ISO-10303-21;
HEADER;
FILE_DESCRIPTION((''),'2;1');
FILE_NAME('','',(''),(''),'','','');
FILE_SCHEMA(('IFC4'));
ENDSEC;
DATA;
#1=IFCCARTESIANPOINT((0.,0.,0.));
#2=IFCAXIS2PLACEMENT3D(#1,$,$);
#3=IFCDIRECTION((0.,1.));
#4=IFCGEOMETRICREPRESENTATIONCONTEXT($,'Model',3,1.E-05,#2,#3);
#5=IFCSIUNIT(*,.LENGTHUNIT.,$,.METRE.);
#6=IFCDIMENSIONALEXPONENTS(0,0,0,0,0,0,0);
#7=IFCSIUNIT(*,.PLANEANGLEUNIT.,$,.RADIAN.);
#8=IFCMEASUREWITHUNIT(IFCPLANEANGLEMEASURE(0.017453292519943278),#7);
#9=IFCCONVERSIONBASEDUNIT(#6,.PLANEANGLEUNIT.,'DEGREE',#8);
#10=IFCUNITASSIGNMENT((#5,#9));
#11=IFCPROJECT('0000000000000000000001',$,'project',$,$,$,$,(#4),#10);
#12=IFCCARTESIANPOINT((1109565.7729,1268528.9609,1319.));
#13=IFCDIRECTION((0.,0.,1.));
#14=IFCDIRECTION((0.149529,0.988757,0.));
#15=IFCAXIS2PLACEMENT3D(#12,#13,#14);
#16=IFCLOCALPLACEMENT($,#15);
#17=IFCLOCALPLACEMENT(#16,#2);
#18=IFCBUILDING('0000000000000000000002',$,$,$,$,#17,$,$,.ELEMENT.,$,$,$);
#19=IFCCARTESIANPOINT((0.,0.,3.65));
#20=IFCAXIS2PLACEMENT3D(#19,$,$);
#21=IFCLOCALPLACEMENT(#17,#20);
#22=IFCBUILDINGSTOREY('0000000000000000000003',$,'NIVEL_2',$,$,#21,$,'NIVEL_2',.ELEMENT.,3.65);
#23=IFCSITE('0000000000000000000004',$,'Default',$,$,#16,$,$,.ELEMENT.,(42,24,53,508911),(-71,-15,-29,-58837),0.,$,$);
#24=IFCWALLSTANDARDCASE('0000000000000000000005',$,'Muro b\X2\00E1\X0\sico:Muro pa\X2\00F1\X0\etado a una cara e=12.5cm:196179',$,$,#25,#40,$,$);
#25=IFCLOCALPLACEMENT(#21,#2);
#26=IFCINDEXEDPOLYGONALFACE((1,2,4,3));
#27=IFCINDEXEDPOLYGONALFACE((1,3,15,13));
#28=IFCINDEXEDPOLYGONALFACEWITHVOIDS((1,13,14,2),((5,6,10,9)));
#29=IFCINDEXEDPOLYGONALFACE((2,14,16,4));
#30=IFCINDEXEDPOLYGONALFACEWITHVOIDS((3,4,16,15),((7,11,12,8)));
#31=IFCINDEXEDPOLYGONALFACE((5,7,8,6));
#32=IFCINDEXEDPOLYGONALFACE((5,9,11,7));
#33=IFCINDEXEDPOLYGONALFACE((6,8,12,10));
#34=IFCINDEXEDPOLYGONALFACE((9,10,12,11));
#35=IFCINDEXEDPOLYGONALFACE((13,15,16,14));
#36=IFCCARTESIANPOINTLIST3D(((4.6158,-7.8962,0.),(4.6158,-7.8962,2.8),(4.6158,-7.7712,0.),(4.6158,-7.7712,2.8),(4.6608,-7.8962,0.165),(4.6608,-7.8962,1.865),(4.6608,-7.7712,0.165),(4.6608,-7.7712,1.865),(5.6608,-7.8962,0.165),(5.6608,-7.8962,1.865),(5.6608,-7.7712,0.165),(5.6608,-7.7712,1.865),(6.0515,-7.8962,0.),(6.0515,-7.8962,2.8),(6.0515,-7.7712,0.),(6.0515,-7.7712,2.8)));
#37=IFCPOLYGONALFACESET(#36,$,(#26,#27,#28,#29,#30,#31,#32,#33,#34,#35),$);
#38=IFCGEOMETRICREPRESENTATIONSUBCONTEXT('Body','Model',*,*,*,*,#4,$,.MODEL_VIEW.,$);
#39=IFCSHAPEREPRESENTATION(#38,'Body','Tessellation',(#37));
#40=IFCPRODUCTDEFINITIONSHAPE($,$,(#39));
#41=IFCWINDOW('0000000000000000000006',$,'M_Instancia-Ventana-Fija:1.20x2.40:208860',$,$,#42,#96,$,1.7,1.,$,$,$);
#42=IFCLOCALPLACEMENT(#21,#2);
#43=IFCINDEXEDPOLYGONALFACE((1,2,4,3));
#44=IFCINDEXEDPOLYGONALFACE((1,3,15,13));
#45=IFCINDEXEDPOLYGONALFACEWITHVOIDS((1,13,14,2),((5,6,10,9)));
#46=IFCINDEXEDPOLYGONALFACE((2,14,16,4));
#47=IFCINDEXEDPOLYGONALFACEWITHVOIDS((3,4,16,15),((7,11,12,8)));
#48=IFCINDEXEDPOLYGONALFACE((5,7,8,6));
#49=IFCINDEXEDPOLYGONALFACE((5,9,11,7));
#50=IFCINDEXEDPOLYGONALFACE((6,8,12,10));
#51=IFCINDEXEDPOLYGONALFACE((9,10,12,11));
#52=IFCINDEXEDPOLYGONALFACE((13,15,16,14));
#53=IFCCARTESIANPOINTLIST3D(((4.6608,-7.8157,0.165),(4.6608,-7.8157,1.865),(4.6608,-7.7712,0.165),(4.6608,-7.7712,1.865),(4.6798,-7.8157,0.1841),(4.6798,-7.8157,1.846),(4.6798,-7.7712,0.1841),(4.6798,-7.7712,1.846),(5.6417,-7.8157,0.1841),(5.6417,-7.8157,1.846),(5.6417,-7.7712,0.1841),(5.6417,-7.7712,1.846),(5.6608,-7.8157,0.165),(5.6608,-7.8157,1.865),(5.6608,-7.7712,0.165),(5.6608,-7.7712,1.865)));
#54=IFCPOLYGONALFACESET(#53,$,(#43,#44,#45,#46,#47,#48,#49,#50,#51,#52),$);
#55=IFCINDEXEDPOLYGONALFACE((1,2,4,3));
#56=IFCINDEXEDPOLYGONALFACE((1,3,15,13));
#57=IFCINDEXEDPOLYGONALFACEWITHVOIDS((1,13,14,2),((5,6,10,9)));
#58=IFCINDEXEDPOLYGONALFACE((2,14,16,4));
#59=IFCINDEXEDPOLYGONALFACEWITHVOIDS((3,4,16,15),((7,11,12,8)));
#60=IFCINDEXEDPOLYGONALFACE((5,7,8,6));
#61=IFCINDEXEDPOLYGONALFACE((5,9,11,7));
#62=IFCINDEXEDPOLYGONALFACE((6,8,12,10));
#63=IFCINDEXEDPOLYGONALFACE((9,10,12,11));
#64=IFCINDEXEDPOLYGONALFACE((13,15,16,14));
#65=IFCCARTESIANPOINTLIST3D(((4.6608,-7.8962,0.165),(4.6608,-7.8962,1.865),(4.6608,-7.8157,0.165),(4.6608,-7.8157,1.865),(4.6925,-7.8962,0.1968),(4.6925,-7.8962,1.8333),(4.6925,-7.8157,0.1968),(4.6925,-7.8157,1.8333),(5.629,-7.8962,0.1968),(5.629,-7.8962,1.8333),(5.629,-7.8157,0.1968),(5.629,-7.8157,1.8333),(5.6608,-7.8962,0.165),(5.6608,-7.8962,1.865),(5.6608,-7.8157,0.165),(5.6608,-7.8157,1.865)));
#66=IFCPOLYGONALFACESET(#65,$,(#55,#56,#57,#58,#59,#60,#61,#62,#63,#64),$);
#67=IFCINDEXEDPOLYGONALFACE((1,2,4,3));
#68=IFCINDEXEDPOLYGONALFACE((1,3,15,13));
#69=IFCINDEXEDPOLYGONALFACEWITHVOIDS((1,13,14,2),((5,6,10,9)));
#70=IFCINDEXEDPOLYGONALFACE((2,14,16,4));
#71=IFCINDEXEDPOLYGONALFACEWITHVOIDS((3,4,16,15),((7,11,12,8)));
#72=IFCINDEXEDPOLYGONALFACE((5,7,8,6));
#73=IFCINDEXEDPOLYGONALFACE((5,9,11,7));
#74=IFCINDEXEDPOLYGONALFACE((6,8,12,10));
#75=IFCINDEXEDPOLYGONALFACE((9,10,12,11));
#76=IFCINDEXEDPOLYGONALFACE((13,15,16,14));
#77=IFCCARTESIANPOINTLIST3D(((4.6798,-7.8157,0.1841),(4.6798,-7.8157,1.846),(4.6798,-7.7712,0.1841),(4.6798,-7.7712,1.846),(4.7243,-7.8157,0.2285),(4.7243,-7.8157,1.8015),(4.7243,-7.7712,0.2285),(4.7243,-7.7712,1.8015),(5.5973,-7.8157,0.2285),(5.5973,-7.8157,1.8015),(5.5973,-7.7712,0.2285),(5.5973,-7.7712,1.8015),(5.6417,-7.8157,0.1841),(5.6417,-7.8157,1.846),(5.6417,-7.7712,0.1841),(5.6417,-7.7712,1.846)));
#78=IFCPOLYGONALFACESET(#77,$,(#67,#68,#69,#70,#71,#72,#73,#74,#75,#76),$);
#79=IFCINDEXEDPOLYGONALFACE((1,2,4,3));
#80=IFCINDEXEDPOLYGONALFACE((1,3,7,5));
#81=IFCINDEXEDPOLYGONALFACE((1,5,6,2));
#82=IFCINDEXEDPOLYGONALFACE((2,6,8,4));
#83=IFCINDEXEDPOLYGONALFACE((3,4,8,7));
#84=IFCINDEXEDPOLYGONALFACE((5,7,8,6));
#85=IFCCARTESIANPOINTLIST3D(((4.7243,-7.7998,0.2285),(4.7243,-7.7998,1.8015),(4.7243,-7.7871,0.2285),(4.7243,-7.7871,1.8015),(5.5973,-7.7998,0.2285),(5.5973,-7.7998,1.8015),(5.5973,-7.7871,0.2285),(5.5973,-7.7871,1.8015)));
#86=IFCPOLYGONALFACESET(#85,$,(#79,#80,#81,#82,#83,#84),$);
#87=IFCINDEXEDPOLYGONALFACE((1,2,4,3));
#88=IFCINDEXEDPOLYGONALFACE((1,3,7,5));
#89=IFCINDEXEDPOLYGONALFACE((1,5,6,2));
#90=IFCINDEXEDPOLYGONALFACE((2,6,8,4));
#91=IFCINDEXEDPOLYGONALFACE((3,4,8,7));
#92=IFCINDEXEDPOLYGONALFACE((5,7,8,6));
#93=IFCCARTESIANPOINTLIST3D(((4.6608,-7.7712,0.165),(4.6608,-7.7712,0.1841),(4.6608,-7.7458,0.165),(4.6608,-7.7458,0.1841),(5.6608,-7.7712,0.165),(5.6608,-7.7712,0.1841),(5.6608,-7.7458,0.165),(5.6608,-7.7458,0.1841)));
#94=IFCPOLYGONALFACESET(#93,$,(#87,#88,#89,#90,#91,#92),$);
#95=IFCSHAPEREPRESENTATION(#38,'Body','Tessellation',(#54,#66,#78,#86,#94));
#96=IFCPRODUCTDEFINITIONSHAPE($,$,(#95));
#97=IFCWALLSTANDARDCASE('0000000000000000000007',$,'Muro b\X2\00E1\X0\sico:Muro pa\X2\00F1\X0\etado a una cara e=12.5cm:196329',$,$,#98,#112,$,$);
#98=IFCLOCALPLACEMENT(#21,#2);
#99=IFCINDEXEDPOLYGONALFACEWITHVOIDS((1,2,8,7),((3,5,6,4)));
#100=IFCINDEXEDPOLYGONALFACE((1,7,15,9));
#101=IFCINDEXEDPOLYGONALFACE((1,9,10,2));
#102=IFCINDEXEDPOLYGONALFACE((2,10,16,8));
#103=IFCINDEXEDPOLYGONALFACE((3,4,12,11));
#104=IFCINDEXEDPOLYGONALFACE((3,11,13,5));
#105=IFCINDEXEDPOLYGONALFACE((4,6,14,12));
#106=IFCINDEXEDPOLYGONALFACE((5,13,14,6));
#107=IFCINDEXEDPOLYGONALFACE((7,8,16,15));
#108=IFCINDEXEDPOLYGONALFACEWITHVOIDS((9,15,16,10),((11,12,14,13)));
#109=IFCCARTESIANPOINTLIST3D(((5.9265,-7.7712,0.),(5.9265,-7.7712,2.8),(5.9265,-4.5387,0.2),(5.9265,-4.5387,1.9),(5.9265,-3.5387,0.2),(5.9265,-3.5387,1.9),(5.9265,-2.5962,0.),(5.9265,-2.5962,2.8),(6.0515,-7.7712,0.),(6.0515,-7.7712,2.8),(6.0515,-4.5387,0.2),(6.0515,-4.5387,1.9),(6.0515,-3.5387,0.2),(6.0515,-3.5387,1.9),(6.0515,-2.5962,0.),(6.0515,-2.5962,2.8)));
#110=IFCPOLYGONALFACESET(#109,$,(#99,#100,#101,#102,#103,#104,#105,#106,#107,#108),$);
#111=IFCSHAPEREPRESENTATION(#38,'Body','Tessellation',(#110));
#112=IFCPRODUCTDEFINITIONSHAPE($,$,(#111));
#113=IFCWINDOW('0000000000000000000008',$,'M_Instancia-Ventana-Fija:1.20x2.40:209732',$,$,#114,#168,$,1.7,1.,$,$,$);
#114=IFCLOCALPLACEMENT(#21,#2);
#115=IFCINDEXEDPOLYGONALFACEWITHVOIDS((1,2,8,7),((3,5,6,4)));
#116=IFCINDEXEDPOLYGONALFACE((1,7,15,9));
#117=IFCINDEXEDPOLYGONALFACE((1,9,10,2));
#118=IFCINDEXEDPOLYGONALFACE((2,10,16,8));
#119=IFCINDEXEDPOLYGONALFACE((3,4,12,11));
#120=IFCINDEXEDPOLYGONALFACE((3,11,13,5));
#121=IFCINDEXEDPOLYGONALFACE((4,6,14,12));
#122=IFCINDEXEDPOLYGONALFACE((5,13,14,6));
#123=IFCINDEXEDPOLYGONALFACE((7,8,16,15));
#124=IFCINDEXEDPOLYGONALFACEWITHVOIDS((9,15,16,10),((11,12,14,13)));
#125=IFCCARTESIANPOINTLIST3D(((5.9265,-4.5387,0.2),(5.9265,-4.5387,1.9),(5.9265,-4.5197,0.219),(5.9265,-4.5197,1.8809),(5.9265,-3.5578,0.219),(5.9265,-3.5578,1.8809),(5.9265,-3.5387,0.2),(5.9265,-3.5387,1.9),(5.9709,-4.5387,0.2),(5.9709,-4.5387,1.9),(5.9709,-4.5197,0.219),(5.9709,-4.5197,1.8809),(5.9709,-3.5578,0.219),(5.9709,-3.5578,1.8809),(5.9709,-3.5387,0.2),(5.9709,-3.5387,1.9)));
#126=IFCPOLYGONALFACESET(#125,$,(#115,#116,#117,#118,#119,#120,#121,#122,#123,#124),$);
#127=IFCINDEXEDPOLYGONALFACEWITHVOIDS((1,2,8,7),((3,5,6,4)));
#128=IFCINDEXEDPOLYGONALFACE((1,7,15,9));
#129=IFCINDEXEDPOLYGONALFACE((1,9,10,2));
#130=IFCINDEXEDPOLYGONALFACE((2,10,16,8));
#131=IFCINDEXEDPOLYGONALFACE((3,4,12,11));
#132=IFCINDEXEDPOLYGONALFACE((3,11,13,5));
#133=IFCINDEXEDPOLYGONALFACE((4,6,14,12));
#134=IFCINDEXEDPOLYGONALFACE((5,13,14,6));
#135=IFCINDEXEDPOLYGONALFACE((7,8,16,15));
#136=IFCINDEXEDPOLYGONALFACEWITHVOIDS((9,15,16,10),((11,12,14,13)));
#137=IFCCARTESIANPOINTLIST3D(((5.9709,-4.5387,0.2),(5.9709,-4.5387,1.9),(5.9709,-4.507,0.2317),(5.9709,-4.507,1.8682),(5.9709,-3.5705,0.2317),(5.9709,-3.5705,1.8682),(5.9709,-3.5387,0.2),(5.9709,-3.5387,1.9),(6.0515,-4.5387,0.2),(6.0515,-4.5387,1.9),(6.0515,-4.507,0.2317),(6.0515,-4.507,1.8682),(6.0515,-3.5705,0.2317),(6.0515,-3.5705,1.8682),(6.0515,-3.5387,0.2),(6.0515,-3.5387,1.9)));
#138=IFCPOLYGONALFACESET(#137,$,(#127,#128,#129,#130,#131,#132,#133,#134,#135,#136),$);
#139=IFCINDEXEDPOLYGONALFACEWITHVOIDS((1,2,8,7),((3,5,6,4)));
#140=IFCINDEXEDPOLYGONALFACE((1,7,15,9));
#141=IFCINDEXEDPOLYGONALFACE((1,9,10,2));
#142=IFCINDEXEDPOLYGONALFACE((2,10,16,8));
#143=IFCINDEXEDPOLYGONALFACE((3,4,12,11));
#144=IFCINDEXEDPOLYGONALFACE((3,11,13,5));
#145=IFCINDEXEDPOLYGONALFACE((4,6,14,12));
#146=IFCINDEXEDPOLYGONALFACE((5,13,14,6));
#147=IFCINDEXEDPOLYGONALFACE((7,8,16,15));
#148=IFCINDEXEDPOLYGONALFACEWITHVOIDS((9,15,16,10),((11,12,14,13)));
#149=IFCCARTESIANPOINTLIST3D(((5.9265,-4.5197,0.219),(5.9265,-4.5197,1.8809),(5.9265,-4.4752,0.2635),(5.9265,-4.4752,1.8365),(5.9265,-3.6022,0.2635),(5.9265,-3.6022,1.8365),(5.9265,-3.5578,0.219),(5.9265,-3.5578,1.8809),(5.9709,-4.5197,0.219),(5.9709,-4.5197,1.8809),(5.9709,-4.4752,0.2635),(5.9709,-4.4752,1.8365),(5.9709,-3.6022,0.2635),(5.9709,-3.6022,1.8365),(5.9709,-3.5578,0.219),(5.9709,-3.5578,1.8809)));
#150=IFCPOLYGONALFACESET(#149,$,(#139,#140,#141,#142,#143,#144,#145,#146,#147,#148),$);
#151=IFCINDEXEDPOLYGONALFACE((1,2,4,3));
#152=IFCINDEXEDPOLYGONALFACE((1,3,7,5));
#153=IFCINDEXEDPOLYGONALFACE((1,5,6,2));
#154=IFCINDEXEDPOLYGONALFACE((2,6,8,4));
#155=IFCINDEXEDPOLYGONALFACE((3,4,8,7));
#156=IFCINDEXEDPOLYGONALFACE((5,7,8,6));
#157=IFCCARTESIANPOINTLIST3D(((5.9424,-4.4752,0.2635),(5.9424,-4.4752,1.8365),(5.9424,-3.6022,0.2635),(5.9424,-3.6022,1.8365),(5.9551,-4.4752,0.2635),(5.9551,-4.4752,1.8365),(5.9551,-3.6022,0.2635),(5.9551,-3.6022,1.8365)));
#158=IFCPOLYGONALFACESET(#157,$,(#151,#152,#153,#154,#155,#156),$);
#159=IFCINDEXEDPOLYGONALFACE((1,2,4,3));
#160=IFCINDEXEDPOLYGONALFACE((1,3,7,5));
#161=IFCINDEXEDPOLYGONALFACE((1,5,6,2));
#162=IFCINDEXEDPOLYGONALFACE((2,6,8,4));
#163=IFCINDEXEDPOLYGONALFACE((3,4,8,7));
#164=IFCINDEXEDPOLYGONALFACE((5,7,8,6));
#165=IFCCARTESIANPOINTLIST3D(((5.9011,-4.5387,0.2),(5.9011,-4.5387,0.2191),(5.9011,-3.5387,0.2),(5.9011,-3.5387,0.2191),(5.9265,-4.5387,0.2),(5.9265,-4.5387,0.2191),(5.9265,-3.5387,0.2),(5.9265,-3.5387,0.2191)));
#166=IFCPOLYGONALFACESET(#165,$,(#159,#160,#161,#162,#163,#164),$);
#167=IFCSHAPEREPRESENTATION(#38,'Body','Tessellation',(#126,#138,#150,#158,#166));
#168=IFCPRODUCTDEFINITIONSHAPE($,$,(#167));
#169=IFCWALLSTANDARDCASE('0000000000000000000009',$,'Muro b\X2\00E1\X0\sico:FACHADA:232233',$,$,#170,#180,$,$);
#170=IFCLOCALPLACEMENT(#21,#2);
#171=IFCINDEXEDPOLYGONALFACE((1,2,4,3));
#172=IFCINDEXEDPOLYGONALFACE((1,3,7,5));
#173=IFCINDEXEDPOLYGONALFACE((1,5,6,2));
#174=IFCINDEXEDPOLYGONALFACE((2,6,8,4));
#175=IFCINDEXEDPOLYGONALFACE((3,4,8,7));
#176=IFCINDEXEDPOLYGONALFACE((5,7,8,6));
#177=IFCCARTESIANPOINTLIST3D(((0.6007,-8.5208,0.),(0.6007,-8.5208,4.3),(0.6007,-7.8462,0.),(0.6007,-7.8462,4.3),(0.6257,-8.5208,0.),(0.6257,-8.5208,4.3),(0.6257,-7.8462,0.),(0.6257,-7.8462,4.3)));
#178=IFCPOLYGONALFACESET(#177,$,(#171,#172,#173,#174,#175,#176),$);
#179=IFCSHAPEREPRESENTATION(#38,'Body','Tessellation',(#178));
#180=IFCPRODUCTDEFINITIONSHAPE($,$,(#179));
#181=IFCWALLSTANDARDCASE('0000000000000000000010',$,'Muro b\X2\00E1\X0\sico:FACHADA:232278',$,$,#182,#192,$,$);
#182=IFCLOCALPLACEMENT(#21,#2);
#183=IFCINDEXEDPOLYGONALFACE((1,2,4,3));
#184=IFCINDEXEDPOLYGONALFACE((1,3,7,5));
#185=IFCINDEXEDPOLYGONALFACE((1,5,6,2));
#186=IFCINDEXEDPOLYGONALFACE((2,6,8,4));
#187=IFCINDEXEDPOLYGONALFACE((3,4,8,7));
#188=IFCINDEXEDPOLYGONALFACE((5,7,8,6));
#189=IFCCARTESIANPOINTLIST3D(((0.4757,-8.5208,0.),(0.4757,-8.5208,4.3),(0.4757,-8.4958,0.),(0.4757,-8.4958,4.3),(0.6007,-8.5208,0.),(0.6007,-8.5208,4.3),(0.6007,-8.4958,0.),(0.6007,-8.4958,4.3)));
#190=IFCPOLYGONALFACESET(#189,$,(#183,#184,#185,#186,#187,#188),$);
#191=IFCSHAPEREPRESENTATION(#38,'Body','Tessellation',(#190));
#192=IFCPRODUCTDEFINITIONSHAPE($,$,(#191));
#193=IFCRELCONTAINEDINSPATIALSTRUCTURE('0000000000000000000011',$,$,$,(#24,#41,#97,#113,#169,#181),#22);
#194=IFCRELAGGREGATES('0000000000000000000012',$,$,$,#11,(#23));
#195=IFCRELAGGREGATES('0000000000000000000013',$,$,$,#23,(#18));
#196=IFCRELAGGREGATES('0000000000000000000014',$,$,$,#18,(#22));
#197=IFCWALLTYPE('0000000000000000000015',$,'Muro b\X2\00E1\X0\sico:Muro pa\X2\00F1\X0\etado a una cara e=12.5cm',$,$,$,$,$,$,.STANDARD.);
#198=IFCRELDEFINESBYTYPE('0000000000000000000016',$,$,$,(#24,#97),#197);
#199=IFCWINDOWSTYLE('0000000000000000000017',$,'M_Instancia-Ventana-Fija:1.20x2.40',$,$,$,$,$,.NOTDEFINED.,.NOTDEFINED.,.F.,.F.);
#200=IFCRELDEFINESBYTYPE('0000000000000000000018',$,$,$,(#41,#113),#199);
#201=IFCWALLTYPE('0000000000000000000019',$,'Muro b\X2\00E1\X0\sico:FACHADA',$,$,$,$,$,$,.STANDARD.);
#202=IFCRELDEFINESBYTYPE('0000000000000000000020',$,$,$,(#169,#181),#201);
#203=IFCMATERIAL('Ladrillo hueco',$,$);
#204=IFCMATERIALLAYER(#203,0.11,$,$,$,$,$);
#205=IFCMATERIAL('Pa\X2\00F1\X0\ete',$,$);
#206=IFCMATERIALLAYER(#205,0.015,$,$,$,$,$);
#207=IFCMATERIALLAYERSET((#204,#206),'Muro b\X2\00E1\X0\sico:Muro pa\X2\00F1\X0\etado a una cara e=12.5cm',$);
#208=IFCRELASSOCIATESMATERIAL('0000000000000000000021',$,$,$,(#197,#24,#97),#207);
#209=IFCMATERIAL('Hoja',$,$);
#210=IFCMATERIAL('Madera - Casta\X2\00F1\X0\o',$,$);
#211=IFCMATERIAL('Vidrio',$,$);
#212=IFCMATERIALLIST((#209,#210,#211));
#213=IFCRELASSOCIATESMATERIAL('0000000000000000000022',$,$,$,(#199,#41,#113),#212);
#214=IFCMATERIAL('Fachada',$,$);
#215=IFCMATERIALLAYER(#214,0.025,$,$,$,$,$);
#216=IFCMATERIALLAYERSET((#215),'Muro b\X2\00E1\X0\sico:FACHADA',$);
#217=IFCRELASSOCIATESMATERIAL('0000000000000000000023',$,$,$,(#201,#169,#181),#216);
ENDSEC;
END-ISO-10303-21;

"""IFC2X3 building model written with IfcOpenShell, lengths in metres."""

from ifc_helpers import new_model, entity, si_unit, converted_unit, direction, frame, frame_2d, origin, origin_2d_with_axis, place, context, subcontext, project, spatial, polyline, rectangle, outline, extrude, source, transform, mapped, material, material_list, layer, layer_set, layer_usage, type_object, type_shapes, element, fill, save


model = new_model("IFC2X3")

# Units and contexts
model_context = context("Model", 3, precision=1e-05, world=origin(), true_north=direction((0.0, 1.0)))
body_context = subcontext(model_context, "Body", "Model", "MODEL_VIEW")
ifc_project = project(units=[si_unit("LENGTHUNIT", "METRE"), converted_unit("PLANEANGLEUNIT", "DEGREE", entity("IfcPlaneAngleMeasure", 0.017453292519943278), si_unit("PLANEANGLEUNIT", "RADIAN"), dimensions=[0, 0, 0, 0, 0, 0, 0])], contexts=[model_context])

# Site, building, storey
site_placement = place(None, frame((1109565.7729, 1268528.9609, 1319.0), z_axis=(0.0, 0.0, 1.0), x_axis=(0.149529, 0.988757, 0.0)))
site = spatial("IfcSite", under=ifc_project, at=site_placement, Name="Default", CompositionType="ELEMENT", RefLatitude=(42, 24, 53, 508911), RefLongitude=(-71, -15, -29, -58837), RefElevation=0.0)
building_placement = place(site_placement, origin())
building = spatial("IfcBuilding", under=site, at=building_placement, CompositionType="ELEMENT")
storey_placement = place(building_placement, frame((0.0, 0.0, 3.65)))
storey = spatial("IfcBuildingStorey", under=building, at=storey_placement, Name="NIVEL_2", LongName="NIVEL_2", CompositionType="ELEMENT", Elevation=3.65)

# Shared definitions
ifc_material_1 = material(Name="Pañete")
ifc_material_2 = material(Name="Ladrillo hueco")
ifc_layer_1 = layer(ifc_material_2, 0.11)
ifc_layer_2 = layer(ifc_material_1, 0.015)
ifc_layer_set_1 = layer_set([ifc_layer_1, ifc_layer_2], Name="Muro básico:Muro pañetado a una cara e=12.5cm")
wall_type_1 = type_object("IfcWallType", Name="Muro básico:Muro pañetado a una cara e=12.5cm", PredefinedType="STANDARD", material=ifc_layer_set_1)

# Shared definitions
ifc_material_3 = material(Name="Hoja")
ifc_material_4 = material(Name="Madera - Castaño")
ifc_material_5 = material(Name="Vidrio")
ifc_material_list = material_list([ifc_material_3, ifc_material_4, ifc_material_5])
window_style = type_object("IfcWindowStyle", Name="M_Instancia-Ventana-Fija:1.20x2.40", ConstructionType="NOTDEFINED", OperationType="NOTDEFINED", ParameterTakesPrecedence=False, Sizeable=False, material=ifc_material_list)
shared_shape = source(origin(), body_context, "Body", "SweptSolid", [
    extrude(outline(polyline([(-0.85, -0.5), (0.85, -0.5), (0.85, 0.5), (-0.85, 0.5), (-0.85, -0.5)]), holes=[polyline([(-0.8309, -0.4809), (-0.8309, 0.481), (0.831, 0.481), (0.831, -0.4809), (-0.8309, -0.4809)])]), frame((0.5, 0.0806, 0.85), z_axis=(0.0, 1.0, 0.0), x_axis=(0.0, 0.0, -1.0)), (0.0, 0.0, 1.0), 0.0444),
    extrude(outline(polyline([(-0.5, -0.85), (0.5, -0.85), (0.5, 0.85), (-0.5, 0.85), (-0.5, -0.85)]), holes=[polyline([(-0.4683, -0.8182), (-0.4683, 0.8183), (0.4682, 0.8183), (0.4682, -0.8182), (-0.4683, -0.8182)])]), frame((0.5, 0.0, 0.85), z_axis=(0.0, 1.0, 0.0), x_axis=(1.0, 0.0, 0.0)), (0.0, 0.0, 1.0), 0.0806),
    extrude(outline(polyline([(-0.4809, -0.831), (0.4809, -0.831), (0.4809, 0.831), (-0.4809, 0.831), (-0.4809, -0.831)]), holes=[polyline([(-0.4365, -0.7865), (-0.4365, 0.7865), (0.4365, 0.7865), (0.4365, -0.7865), (-0.4365, -0.7865)])]), frame((0.5, 0.0806, 0.85), z_axis=(0.0, 1.0, 0.0), x_axis=(1.0, 0.0, 0.0)), (0.0, 0.0, 1.0), 0.0444),
    extrude(rectangle(XDim=0.0127, YDim=0.873, at=frame_2d((0.0, 0.0), x_axis=(1.0, 0.0))), frame((0.5, 0.1028, 0.0635), z_axis=(0.0, 0.0, 1.0), x_axis=(0.0, 1.0, 0.0)), (0.0, 0.0, 1.0), 1.573),
    extrude(rectangle(XDim=0.0254, YDim=1.0, at=origin_2d_with_axis()), frame((0.5, 0.1377, 0.0), z_axis=(0.0, 0.0, 1.0), x_axis=(0.0, -1.0, 0.0)), (0.0, 0.0, 1.0), 0.019),
])
type_shapes(window_style, [shared_shape])

# Walls, openings, windows
ifc_layer_usage_1 = layer_usage(ifc_layer_set_1, "AXIS2", "POSITIVE", -0.0625)
wall_1_placement = place(storey_placement, frame((4.6158, -7.8337, 0.0)))
wall_1 = element("IfcWallStandardCase", 1, at=wall_1_placement, inside=storey, type_object=wall_type_1, material=ifc_layer_usage_1, Name="Muro básico:Muro pañetado a una cara e=12.5cm:196179", context=body_context, shape_type="SweptSolid", body=[
    extrude(rectangle(XDim=1.4357, YDim=0.125, at=frame_2d((0.7179, 0.0), x_axis=(-1.0, 0.0))), origin(), (0.0, 0.0, 1.0), 2.8),
])
opening_1_placement = place(wall_1_placement, frame((0.045, -0.0625, 0.165)))
opening_1 = element("IfcOpeningElement", 2, at=opening_1_placement, cuts=wall_1, ObjectType="Opening", context=body_context, shape_type="SweptSolid", body=[
    extrude(rectangle(XDim=1.7, YDim=1.0, at=frame_2d((0.85, 0.5), x_axis=(-1.0, 0.0))), frame((0.0, 0.0, 0.0), z_axis=(0.0, 1.0, 0.0), x_axis=(0.0, 0.0, 1.0)), (0.0, 0.0, 1.0), 0.125),
])
window_1_placement = place(opening_1_placement, origin())
window_1 = element("IfcWindow", 3, at=window_1_placement, inside=storey, type_object=window_style, material=ifc_material_list, Name="M_Instancia-Ventana-Fija:1.20x2.40:208860", OverallHeight=1.7, OverallWidth=1.0, context=body_context, shape_type="MappedRepresentation", body=[
    mapped(shared_shape, transform((0.0, 0.0, 0.0), scale=1.0)),
])
fill(opening_1, window_1)
ifc_layer_usage_2 = layer_usage(ifc_layer_set_1, "AXIS2", "POSITIVE", -0.0625)
wall_2_placement = place(storey_placement, frame((5.989, -7.7712, 0.0), z_axis=(0.0, 0.0, 1.0), x_axis=(0.0, 1.0, 0.0)))
wall_2 = element("IfcWallStandardCase", 4, at=wall_2_placement, inside=storey, type_object=wall_type_1, material=ifc_layer_usage_2, Name="Muro básico:Muro pañetado a una cara e=12.5cm:196329", context=body_context, shape_type="SweptSolid", body=[
    extrude(rectangle(XDim=5.175, YDim=0.125, at=frame_2d((2.5875, 0.0), x_axis=(-1.0, 0.0))), origin(), (0.0, 0.0, 1.0), 2.8),
])
opening_2_placement = place(wall_2_placement, frame((3.2325, -0.0625, 0.2)))
opening_2 = element("IfcOpeningElement", 5, at=opening_2_placement, cuts=wall_2, ObjectType="Opening", context=body_context, shape_type="SweptSolid", body=[
    extrude(rectangle(XDim=1.7, YDim=1.0, at=frame_2d((0.85, 0.5), x_axis=(-1.0, 0.0))), frame((0.0, 0.0, 0.0), z_axis=(0.0, 1.0, 0.0), x_axis=(0.0, 0.0, 1.0)), (0.0, 0.0, 1.0), 0.125),
])
window_2_placement = place(opening_2_placement, origin())
window_2 = element("IfcWindow", 6, at=window_2_placement, inside=storey, type_object=window_style, material=ifc_material_list, Name="M_Instancia-Ventana-Fija:1.20x2.40:209732", OverallHeight=1.7, OverallWidth=1.0, context=body_context, shape_type="MappedRepresentation", body=[
    mapped(shared_shape, transform((0.0, 0.0, 0.0), scale=1.0)),
])
fill(opening_2, window_2)

# Walls
ifc_material_6 = material(Name="Fachada")
ifc_layer_3 = layer(ifc_material_6, 0.025)
ifc_layer_set_2 = layer_set([ifc_layer_3], Name="Muro básico:FACHADA")
ifc_layer_usage_3 = layer_usage(ifc_layer_set_2, "AXIS2", "NEGATIVE", 0.0125)
wall_type_2 = type_object("IfcWallType", Name="Muro básico:FACHADA", PredefinedType="STANDARD", material=ifc_layer_set_2)
wall_3_placement = place(storey_placement, frame((0.6132, -7.8462, 0.0), z_axis=(0.0, 0.0, 1.0), x_axis=(0.0, -1.0, 0.0)))
element("IfcWallStandardCase", 7, at=wall_3_placement, inside=storey, type_object=wall_type_2, material=ifc_layer_usage_3, Name="Muro básico:FACHADA:232233", context=body_context, shape_type="SweptSolid", body=[
    extrude(rectangle(XDim=0.6746, YDim=0.025, at=frame_2d((0.3373, 0.0), x_axis=(-1.0, 0.0))), origin(), (0.0, 0.0, 1.0), 4.3),
])
ifc_layer_usage_4 = layer_usage(ifc_layer_set_2, "AXIS2", "NEGATIVE", 0.0125)
wall_4_placement = place(storey_placement, frame((0.6007, -8.5083, 0.0), z_axis=(0.0, 0.0, 1.0), x_axis=(-1.0, 0.0, 0.0)))
element("IfcWallStandardCase", 8, at=wall_4_placement, inside=storey, type_object=wall_type_2, material=ifc_layer_usage_4, Name="Muro básico:FACHADA:232278", context=body_context, shape_type="SweptSolid", body=[
    extrude(rectangle(XDim=0.125, YDim=0.025, at=frame_2d((0.0625, 0.0), x_axis=(-1.0, 0.0))), origin(), (0.0, 0.0, 1.0), 4.3),
])

save(model, "model.ifc")
